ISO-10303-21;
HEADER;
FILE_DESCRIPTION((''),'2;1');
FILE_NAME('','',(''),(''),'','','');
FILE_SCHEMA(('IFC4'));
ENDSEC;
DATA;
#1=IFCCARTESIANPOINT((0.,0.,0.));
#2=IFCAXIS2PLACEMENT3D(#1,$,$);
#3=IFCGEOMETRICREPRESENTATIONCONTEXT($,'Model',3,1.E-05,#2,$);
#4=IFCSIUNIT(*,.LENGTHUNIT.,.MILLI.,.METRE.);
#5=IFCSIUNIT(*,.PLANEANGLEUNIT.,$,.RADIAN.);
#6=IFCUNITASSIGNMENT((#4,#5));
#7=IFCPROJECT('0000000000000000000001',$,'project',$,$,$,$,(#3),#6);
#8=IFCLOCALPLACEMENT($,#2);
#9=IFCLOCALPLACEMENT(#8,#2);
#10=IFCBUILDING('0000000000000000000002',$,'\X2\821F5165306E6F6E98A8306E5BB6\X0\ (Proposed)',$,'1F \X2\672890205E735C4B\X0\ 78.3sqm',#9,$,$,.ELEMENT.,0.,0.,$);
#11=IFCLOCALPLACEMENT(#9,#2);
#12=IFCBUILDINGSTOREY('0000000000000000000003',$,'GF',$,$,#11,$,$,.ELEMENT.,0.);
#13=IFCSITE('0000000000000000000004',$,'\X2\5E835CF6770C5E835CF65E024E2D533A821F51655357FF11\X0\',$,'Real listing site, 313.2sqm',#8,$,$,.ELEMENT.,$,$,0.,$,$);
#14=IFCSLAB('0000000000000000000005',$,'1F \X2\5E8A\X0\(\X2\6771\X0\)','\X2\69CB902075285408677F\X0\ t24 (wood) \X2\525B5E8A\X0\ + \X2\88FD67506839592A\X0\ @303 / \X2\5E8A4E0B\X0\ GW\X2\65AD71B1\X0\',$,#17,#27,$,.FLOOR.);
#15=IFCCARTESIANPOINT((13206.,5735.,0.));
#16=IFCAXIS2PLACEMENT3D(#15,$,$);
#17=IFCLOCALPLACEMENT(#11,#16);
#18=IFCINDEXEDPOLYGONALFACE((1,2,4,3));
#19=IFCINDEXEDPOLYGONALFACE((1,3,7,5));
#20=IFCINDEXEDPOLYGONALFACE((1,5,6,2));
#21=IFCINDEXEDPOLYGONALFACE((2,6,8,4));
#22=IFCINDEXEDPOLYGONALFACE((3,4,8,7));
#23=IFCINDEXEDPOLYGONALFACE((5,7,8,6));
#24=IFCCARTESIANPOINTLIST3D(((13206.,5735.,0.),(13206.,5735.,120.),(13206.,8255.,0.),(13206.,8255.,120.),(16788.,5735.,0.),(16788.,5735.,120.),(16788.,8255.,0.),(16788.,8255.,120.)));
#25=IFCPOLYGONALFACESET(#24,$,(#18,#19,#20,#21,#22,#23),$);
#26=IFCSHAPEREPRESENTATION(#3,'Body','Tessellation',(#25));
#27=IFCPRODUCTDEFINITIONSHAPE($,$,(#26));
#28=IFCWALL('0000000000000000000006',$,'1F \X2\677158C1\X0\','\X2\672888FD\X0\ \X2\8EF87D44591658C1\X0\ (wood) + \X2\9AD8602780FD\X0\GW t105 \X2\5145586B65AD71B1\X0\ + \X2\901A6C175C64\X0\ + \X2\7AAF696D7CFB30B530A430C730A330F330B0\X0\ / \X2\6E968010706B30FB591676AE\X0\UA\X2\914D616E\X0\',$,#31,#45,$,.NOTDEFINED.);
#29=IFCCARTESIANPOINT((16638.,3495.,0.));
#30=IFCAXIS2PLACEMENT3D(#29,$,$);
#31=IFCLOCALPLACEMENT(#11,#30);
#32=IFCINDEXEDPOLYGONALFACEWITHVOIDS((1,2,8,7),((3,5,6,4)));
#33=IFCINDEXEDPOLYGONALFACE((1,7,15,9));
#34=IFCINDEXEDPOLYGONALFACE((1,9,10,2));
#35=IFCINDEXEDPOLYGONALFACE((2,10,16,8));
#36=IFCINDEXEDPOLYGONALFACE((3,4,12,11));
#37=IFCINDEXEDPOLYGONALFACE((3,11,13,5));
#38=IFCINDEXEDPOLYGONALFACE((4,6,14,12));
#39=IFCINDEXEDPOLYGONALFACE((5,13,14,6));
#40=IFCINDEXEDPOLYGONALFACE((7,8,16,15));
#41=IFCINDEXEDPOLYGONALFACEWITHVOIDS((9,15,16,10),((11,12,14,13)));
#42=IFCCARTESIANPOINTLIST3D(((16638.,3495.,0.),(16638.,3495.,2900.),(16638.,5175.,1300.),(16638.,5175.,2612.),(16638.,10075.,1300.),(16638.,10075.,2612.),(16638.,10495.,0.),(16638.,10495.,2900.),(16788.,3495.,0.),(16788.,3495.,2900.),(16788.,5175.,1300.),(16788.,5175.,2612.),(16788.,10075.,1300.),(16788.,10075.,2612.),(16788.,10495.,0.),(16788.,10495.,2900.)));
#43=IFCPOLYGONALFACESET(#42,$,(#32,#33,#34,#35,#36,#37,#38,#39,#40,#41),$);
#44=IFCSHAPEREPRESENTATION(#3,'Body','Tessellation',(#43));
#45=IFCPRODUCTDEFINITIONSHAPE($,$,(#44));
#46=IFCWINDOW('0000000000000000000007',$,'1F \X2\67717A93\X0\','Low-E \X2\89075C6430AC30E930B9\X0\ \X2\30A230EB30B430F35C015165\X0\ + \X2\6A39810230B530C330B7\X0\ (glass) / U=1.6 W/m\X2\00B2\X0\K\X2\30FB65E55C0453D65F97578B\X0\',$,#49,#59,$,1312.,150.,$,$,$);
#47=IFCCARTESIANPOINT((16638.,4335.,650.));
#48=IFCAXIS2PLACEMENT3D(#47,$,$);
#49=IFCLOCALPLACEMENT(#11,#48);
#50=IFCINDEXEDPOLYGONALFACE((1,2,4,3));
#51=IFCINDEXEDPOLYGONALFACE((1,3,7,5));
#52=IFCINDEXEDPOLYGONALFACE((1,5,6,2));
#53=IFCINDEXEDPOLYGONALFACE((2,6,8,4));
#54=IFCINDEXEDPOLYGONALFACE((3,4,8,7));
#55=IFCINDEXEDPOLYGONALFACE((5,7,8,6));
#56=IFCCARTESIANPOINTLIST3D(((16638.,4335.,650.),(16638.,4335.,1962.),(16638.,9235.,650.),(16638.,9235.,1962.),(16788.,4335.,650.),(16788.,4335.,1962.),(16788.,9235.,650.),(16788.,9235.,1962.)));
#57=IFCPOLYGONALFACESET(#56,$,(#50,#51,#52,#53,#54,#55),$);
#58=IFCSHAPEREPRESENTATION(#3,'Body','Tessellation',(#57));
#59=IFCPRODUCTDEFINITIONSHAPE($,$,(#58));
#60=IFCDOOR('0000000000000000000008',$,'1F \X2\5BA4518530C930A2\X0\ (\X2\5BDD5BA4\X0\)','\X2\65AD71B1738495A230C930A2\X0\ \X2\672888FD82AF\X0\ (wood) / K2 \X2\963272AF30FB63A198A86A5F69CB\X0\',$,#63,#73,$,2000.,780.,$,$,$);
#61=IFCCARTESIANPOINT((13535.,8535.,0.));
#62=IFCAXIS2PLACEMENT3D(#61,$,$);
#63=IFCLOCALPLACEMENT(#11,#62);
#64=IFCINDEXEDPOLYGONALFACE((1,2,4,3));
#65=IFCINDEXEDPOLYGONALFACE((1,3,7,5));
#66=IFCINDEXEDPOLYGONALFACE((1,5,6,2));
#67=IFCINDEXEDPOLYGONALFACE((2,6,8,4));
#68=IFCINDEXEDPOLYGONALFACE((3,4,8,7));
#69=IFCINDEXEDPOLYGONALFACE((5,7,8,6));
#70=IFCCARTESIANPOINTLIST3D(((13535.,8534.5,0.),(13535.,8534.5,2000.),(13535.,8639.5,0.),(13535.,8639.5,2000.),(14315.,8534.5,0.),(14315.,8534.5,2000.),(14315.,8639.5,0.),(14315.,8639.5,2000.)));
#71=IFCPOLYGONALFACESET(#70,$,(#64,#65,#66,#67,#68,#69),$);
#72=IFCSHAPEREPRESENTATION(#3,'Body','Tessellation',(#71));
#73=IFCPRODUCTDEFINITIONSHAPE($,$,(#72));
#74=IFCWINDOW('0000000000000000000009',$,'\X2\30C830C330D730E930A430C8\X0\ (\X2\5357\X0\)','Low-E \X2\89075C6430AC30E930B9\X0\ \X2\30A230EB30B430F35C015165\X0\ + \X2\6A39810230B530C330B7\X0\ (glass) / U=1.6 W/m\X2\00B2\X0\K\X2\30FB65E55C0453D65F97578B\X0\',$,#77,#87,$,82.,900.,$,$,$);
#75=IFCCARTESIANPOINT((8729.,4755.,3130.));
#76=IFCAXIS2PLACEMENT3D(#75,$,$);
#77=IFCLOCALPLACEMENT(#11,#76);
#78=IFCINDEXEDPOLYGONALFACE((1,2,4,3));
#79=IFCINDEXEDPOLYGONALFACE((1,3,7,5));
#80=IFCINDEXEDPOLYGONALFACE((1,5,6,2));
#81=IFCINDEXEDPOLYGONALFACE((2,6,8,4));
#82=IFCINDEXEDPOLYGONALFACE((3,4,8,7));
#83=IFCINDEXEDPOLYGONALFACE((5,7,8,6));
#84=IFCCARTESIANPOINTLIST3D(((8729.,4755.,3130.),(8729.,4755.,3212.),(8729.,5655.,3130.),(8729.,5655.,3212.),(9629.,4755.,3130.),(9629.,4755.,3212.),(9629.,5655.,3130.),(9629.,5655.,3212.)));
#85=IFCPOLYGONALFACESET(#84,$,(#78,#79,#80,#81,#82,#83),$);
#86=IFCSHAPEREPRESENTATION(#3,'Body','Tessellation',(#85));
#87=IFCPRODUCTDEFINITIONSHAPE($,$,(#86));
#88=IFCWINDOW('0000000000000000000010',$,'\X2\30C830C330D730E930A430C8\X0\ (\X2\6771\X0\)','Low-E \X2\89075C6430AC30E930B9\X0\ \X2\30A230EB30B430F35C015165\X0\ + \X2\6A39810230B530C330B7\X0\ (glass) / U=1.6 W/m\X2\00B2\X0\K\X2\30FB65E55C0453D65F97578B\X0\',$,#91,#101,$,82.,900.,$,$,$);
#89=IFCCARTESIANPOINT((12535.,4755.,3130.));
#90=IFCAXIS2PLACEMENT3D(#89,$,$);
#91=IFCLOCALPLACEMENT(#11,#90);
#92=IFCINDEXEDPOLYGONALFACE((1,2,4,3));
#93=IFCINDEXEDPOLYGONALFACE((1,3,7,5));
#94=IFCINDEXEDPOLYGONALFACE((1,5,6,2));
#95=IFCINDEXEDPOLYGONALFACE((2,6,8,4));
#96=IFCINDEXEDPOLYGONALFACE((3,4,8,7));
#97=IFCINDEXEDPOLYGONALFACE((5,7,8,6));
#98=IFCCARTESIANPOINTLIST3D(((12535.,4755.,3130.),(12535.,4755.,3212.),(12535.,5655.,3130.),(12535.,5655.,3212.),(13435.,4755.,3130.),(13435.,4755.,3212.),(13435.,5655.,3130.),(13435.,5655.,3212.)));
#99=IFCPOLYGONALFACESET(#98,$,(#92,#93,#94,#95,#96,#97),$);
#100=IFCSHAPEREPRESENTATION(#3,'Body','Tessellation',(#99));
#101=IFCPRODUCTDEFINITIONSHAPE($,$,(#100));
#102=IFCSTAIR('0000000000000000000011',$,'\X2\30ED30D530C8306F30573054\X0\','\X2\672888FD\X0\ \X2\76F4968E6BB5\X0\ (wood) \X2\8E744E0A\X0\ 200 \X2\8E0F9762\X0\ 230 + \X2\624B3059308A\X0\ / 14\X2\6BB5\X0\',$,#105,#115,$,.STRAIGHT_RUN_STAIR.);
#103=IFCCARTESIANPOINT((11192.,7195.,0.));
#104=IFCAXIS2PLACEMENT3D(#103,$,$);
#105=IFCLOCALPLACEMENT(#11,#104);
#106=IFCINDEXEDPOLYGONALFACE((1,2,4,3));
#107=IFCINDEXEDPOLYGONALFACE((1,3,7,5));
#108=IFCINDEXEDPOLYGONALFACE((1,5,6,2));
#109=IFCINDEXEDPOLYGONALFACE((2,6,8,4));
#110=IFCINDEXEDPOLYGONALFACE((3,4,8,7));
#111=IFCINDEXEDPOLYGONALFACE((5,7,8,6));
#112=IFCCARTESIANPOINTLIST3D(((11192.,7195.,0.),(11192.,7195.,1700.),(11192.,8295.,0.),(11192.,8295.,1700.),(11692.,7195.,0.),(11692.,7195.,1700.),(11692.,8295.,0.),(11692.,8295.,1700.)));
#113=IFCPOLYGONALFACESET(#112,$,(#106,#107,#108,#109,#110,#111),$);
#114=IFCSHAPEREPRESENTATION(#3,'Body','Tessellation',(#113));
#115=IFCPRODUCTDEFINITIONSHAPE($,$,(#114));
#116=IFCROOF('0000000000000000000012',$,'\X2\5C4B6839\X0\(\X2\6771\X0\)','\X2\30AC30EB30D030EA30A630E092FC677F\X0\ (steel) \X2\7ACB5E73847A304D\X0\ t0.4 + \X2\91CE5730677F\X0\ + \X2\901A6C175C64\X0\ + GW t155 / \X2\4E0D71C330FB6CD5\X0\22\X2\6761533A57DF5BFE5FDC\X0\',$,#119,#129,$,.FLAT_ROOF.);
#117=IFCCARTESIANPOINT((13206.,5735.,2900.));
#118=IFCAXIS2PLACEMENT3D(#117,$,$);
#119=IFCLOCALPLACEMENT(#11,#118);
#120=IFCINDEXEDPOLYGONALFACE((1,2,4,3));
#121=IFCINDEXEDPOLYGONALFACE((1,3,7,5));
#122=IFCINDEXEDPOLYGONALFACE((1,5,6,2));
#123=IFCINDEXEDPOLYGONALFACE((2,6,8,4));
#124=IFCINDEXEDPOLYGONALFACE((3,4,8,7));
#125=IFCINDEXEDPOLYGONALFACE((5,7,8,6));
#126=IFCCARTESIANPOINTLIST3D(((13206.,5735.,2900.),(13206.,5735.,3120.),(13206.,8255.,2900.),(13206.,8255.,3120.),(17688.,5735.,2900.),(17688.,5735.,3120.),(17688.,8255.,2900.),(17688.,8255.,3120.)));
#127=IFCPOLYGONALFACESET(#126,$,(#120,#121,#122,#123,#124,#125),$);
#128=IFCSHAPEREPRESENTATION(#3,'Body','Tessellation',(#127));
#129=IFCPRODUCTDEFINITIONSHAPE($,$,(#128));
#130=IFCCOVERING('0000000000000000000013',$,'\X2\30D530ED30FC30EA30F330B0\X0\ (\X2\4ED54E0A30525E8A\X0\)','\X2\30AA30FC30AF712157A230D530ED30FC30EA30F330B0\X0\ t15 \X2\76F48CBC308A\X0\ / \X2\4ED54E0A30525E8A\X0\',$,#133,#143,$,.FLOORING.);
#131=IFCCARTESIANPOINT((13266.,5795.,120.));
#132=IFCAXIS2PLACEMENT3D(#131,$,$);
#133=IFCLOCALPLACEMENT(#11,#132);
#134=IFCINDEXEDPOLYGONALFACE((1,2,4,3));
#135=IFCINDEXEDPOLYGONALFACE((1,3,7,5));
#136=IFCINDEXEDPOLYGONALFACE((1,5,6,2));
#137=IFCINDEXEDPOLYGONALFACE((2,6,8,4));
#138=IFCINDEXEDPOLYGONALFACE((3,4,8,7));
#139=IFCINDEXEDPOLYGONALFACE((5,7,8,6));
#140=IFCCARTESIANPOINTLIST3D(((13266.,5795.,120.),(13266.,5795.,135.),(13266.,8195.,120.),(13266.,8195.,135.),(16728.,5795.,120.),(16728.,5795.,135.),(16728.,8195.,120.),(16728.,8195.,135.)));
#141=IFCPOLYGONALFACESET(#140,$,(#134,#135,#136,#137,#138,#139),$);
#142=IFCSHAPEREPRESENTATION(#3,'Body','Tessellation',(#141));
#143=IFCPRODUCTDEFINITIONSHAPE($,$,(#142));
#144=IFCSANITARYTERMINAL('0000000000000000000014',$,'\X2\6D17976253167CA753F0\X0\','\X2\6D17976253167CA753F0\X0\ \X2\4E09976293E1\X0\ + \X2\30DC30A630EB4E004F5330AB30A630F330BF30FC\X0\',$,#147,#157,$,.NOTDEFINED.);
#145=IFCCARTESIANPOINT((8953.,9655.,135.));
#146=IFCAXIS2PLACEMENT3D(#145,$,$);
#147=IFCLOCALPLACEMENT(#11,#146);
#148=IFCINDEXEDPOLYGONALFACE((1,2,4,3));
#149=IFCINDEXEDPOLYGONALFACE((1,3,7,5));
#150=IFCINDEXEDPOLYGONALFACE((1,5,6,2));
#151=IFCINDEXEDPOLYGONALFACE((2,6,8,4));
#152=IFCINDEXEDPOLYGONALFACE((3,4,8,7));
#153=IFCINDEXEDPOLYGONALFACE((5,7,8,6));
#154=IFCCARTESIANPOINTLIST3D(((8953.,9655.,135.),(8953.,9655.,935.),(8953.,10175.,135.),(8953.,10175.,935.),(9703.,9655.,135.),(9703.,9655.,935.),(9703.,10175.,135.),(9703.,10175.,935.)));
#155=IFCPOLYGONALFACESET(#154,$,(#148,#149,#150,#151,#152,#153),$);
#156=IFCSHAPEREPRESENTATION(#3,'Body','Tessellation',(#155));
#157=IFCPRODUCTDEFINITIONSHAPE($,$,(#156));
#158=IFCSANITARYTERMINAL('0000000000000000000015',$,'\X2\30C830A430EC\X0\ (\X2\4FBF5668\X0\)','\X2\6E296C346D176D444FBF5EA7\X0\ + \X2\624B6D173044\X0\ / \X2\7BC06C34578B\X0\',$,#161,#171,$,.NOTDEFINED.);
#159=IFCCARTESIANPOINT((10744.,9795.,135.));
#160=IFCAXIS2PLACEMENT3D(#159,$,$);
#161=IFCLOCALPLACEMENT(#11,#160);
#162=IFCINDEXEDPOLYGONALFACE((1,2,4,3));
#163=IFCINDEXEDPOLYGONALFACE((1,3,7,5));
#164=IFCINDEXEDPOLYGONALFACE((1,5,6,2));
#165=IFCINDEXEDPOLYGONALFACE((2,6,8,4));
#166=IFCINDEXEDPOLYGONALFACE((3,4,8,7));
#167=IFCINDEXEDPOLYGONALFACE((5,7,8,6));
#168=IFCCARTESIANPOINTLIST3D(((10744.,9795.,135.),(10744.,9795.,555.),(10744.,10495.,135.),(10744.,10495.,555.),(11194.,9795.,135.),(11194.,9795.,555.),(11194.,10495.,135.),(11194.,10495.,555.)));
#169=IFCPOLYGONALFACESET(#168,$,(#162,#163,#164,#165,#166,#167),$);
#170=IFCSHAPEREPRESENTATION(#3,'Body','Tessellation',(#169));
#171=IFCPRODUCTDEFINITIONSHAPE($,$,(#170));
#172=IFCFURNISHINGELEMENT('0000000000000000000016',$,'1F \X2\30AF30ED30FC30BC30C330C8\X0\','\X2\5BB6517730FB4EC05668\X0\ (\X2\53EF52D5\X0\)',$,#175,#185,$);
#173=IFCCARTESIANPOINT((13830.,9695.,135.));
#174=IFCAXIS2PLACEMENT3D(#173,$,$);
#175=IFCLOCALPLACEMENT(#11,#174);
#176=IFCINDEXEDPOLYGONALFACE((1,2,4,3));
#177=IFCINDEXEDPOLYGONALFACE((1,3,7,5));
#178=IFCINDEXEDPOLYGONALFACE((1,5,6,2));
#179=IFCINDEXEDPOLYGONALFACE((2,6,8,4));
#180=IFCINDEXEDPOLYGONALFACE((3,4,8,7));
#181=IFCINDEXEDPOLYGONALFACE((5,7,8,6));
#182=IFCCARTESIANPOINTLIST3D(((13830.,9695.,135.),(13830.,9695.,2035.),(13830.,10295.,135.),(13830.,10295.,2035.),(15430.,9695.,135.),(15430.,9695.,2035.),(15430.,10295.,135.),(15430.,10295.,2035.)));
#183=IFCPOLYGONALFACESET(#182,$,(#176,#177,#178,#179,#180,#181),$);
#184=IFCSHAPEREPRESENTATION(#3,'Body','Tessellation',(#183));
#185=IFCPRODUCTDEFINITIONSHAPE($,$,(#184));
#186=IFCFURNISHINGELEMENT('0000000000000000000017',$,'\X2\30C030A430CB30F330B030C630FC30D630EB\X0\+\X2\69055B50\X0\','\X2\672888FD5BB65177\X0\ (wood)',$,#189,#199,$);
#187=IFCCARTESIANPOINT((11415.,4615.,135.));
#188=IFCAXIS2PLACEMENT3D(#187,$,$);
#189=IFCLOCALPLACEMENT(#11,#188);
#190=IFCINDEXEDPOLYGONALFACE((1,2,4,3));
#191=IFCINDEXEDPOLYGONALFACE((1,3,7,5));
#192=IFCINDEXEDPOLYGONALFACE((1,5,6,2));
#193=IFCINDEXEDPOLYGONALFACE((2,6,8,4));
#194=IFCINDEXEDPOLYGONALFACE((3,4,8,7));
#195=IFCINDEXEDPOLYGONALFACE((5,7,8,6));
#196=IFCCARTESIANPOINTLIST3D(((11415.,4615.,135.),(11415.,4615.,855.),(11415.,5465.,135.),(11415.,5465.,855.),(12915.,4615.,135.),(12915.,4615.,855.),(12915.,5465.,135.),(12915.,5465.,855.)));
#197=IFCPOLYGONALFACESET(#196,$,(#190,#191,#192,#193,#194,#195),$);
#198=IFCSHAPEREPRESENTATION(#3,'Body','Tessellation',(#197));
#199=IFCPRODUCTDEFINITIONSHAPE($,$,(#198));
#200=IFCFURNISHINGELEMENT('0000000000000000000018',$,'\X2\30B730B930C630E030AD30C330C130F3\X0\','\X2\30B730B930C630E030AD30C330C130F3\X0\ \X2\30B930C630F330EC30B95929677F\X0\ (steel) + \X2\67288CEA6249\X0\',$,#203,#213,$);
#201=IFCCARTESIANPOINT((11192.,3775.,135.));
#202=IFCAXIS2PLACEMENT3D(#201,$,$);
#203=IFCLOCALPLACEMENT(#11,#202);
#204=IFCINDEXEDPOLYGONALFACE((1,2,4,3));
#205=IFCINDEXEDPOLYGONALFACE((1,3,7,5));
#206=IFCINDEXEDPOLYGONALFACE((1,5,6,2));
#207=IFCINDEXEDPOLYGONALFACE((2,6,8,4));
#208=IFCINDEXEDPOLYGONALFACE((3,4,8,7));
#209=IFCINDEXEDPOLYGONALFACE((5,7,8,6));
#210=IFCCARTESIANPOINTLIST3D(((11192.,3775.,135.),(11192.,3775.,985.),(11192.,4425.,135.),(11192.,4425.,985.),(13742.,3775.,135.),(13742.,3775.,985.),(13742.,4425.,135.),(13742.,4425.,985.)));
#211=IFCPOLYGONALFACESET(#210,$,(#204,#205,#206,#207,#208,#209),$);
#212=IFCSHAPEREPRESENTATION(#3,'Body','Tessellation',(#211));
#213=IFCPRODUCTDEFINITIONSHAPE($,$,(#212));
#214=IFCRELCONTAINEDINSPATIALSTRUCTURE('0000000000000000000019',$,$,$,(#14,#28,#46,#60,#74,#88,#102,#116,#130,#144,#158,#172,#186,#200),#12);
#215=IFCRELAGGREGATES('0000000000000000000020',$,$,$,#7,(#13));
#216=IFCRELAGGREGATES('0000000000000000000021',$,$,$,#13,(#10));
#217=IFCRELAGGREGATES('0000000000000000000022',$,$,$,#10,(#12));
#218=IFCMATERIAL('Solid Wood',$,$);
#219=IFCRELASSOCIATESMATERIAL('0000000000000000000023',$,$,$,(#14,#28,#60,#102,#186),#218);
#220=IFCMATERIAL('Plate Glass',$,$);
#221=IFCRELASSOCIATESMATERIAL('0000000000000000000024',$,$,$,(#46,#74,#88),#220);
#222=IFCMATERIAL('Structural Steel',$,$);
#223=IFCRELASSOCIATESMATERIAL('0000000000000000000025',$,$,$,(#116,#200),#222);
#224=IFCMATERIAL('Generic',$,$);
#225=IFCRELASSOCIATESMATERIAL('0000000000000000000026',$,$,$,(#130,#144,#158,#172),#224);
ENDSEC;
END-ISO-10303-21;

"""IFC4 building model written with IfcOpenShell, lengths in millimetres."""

from ifc_helpers import new_model, si_unit, frame, frame_2d, origin, place, context, project, spatial, rectangle, extrude, material, element, fill, save


model = new_model("IFC4")

# Units and contexts
model_context = context("Model", 3, precision=1e-05, world=origin())
ifc_project = project(units=[si_unit("LENGTHUNIT", "METRE", prefix="MILLI"), si_unit("PLANEANGLEUNIT", "RADIAN")], contexts=[model_context])

# Site, building, storey
site_placement = place(None, origin())
site = spatial("IfcSite", under=ifc_project, at=site_placement, Name="広島県広島市中区舟入南１", ObjectType="Real listing site, 313.2sqm", CompositionType="ELEMENT", RefElevation=0.0)
building_placement = place(site_placement, origin())
building = spatial("IfcBuilding", under=site, at=building_placement, Name="舟入の潮風の家 (Proposed)", ObjectType="1F 木造平屋 78.3sqm", CompositionType="ELEMENT", ElevationOfRefHeight=0.0, ElevationOfTerrain=0.0)
storey_placement = place(building_placement, origin())
storey = spatial("IfcBuildingStorey", under=building, at=storey_placement, Name="GF", CompositionType="ELEMENT", Elevation=0.0)

# Slab
ifc_material_1 = material(Name="Solid Wood")
slab_1_placement = place(storey_placement, frame((13206.0, 5735.0, 0.0)))
element("IfcSlab", 1, at=slab_1_placement, inside=storey, material=ifc_material_1, Name="1F 床(東)", Description="構造用合板 t24 (wood) 剛床 + 製材根太 @303 / 床下 GW断熱", PredefinedType="FLOOR", context=model_context, shape_type="SweptSolid", body=[
    extrude(rectangle(XDim=3582.0, YDim=2520.0, at=frame_2d((1791.0, 1260.0))), frame((13206.0, 5735.0, 0.0)), (0.0, 0.0, 1.0), 120.0),
])

# Wall, opening, window
wall_1_placement = place(storey_placement, frame((16638.0, 3495.0, 0.0)))
wall_1 = element("IfcWall", 2, at=wall_1_placement, inside=storey, material=ifc_material_1, Name="1F 東壁", Description="木製 軸組外壁 (wood) + 高性能GW t105 充填断熱 + 通気層 + 窯業系サイディング / 準耐火・外皮UA配慮", PredefinedType="NOTDEFINED", context=model_context, shape_type="SweptSolid", body=[
    extrude(rectangle(XDim=150.0, YDim=7000.0, at=frame_2d((75.0, 3500.0))), frame((16638.0, 3495.0, 0.0)), (0.0, 0.0, 1.0), 2900.0),
])
opening_1_placement = place(storey_placement, frame((16638.0, 4335.0, 650.0)))
opening_1 = element("IfcOpeningElement", 3, at=opening_1_placement, cuts=wall_1, PredefinedType="NOTDEFINED", context=model_context, shape_type="SweptSolid", body=[
    extrude(rectangle(XDim=150.0, YDim=4900.0, at=frame_2d((75.0, 2450.0))), frame((16638.0, 4335.0, 650.0)), (0.0, 0.0, 1.0), 1312.0),
])
ifc_material_2 = material(Name="Plate Glass")
window_1_placement = place(storey_placement, frame((16638.0, 4335.0, 650.0)))
window_1 = element("IfcWindow", 4, at=window_1_placement, inside=storey, material=ifc_material_2, Name="1F 東窓", Description="Low-E 複層ガラス アルゴン封入 + 樹脂サッシ (glass) / U=1.6 W/m²K・日射取得型", OverallHeight=1312.0, OverallWidth=150.0, context=model_context, shape_type="SweptSolid", body=[
    extrude(rectangle(XDim=150.0, YDim=4900.0, at=frame_2d((75.0, 2450.0))), frame((16638.0, 4335.0, 650.0)), (0.0, 0.0, 1.0), 1312.0),
])
fill(opening_1, window_1)

# Door
door_placement = place(storey_placement, frame((13535.0, 8535.0, 0.0)))
element("IfcDoor", 5, at=door_placement, inside=storey, material=ifc_material_1, Name="1F 室内ドア (寝室)", Description="断熱玄関ドア 木製芯 (wood) / K2 防犯・採風機構", OverallHeight=2000.0, OverallWidth=780.0, context=model_context, shape_type="SweptSolid", body=[
    extrude(rectangle(XDim=780.0, YDim=105.0, at=frame_2d((390.0, 52.0))), frame((13535.0, 8535.0, 0.0)), (0.0, 0.0, 1.0), 2000.0),
])

# Windows
window_2_placement = place(storey_placement, frame((8729.0, 4755.0, 3130.0)))
element("IfcWindow", 6, at=window_2_placement, inside=storey, material=ifc_material_2, Name="トップライト (南)", Description="Low-E 複層ガラス アルゴン封入 + 樹脂サッシ (glass) / U=1.6 W/m²K・日射取得型", OverallHeight=82.0, OverallWidth=900.0, context=model_context, shape_type="SweptSolid", body=[
    extrude(rectangle(XDim=900.0, YDim=900.0, at=frame_2d((450.0, 450.0))), frame((8729.0, 4755.0, 3130.0)), (0.0, 0.0, 1.0), 82.0),
])
window_3_placement = place(storey_placement, frame((12535.0, 4755.0, 3130.0)))
element("IfcWindow", 7, at=window_3_placement, inside=storey, material=ifc_material_2, Name="トップライト (東)", Description="Low-E 複層ガラス アルゴン封入 + 樹脂サッシ (glass) / U=1.6 W/m²K・日射取得型", OverallHeight=82.0, OverallWidth=900.0, context=model_context, shape_type="SweptSolid", body=[
    extrude(rectangle(XDim=900.0, YDim=900.0, at=frame_2d((450.0, 450.0))), frame((12535.0, 4755.0, 3130.0)), (0.0, 0.0, 1.0), 82.0),
])

# Stair
stair_placement = place(storey_placement, frame((11192.0, 7195.0, 0.0)))
element("IfcStair", 8, at=stair_placement, inside=storey, material=ifc_material_1, Name="ロフトはしご", Description="木製 直階段 (wood) 蹴上 200 踏面 230 + 手すり / 14段", PredefinedType="STRAIGHT_RUN_STAIR", context=model_context, shape_type="SweptSolid", body=[
    extrude(rectangle(XDim=500.0, YDim=1100.0, at=frame_2d((250.0, 550.0))), frame((11192.0, 7195.0, 0.0)), (0.0, 0.0, 1.0), 1700.0),
])

# Roof
ifc_material_3 = material(Name="Structural Steel")
roof_placement = place(storey_placement, frame((13206.0, 5735.0, 2900.0)))
element("IfcRoof", 9, at=roof_placement, inside=storey, material=ifc_material_3, Name="屋根(東)", Description="ガルバリウム鋼板 (steel) 立平葺き t0.4 + 野地板 + 通気層 + GW t155 / 不燃・法22条区域対応", PredefinedType="FLAT_ROOF", context=model_context, shape_type="SweptSolid", body=[
    extrude(rectangle(XDim=4482.0, YDim=2520.0, at=frame_2d((2241.0, 1260.0))), frame((13206.0, 5735.0, 2900.0)), (0.0, 0.0, 1.0), 220.0),
])

# Covering
ifc_material_4 = material(Name="Generic")
covering_placement = place(storey_placement, frame((13266.0, 5795.0, 120.0)))
element("IfcCovering", 10, at=covering_placement, inside=storey, material=ifc_material_4, Name="フローリング (仕上げ床)", Description="オーク無垢フローリング t15 直貼り / 仕上げ床", PredefinedType="FLOORING", context=model_context, shape_type="SweptSolid", body=[
    extrude(rectangle(XDim=3462.0, YDim=2400.0, at=frame_2d((1731.0, 1200.0))), frame((13266.0, 5795.0, 120.0)), (0.0, 0.0, 1.0), 15.0),
])

# Sanitary terminals
sanitary_terminal_1_placement = place(storey_placement, frame((8953.0, 9655.0, 135.0)))
element("IfcSanitaryTerminal", 11, at=sanitary_terminal_1_placement, inside=storey, material=ifc_material_4, Name="洗面化粧台", Description="洗面化粧台 三面鏡 + ボウル一体カウンター", PredefinedType="NOTDEFINED", context=model_context, shape_type="SweptSolid", body=[
    extrude(rectangle(XDim=750.0, YDim=520.0, at=frame_2d((375.0, 260.0))), frame((8953.0, 9655.0, 135.0)), (0.0, 0.0, 1.0), 800.0),
])
sanitary_terminal_2_placement = place(storey_placement, frame((10744.0, 9795.0, 135.0)))
element("IfcSanitaryTerminal", 12, at=sanitary_terminal_2_placement, inside=storey, material=ifc_material_4, Name="トイレ (便器)", Description="温水洗浄便座 + 手洗い / 節水型", PredefinedType="NOTDEFINED", context=model_context, shape_type="SweptSolid", body=[
    extrude(rectangle(XDim=450.0, YDim=700.0, at=frame_2d((225.0, 350.0))), frame((10744.0, 9795.0, 135.0)), (0.0, 0.0, 1.0), 420.0),
])

# Furnishing elements
furnishing_1_placement = place(storey_placement, frame((13830.0, 9695.0, 135.0)))
element("IfcFurnishingElement", 13, at=furnishing_1_placement, inside=storey, material=ifc_material_4, Name="1F クローゼット", Description="家具・什器 (可動)", context=model_context, shape_type="SweptSolid", body=[
    extrude(rectangle(XDim=1600.0, YDim=600.0, at=frame_2d((800.0, 300.0))), frame((13830.0, 9695.0, 135.0)), (0.0, 0.0, 1.0), 1900.0),
])
furnishing_2_placement = place(storey_placement, frame((11415.0, 4615.0, 135.0)))
element("IfcFurnishingElement", 14, at=furnishing_2_placement, inside=storey, material=ifc_material_1, Name="ダイニングテーブル+椅子", Description="木製家具 (wood)", context=model_context, shape_type="SweptSolid", body=[
    extrude(rectangle(XDim=1500.0, YDim=850.0, at=frame_2d((750.0, 425.0))), frame((11415.0, 4615.0, 135.0)), (0.0, 0.0, 1.0), 720.0),
])
furnishing_3_placement = place(storey_placement, frame((11192.0, 3775.0, 135.0)))
element("IfcFurnishingElement", 15, at=furnishing_3_placement, inside=storey, material=ifc_material_3, Name="システムキッチン", Description="システムキッチン ステンレス天板 (steel) + 木質扉", context=model_context, shape_type="SweptSolid", body=[
    extrude(rectangle(XDim=2550.0, YDim=650.0, at=frame_2d((1275.0, 325.0))), frame((11192.0, 3775.0, 135.0)), (0.0, 0.0, 1.0), 850.0),
])

save(model, "model.ifc")
